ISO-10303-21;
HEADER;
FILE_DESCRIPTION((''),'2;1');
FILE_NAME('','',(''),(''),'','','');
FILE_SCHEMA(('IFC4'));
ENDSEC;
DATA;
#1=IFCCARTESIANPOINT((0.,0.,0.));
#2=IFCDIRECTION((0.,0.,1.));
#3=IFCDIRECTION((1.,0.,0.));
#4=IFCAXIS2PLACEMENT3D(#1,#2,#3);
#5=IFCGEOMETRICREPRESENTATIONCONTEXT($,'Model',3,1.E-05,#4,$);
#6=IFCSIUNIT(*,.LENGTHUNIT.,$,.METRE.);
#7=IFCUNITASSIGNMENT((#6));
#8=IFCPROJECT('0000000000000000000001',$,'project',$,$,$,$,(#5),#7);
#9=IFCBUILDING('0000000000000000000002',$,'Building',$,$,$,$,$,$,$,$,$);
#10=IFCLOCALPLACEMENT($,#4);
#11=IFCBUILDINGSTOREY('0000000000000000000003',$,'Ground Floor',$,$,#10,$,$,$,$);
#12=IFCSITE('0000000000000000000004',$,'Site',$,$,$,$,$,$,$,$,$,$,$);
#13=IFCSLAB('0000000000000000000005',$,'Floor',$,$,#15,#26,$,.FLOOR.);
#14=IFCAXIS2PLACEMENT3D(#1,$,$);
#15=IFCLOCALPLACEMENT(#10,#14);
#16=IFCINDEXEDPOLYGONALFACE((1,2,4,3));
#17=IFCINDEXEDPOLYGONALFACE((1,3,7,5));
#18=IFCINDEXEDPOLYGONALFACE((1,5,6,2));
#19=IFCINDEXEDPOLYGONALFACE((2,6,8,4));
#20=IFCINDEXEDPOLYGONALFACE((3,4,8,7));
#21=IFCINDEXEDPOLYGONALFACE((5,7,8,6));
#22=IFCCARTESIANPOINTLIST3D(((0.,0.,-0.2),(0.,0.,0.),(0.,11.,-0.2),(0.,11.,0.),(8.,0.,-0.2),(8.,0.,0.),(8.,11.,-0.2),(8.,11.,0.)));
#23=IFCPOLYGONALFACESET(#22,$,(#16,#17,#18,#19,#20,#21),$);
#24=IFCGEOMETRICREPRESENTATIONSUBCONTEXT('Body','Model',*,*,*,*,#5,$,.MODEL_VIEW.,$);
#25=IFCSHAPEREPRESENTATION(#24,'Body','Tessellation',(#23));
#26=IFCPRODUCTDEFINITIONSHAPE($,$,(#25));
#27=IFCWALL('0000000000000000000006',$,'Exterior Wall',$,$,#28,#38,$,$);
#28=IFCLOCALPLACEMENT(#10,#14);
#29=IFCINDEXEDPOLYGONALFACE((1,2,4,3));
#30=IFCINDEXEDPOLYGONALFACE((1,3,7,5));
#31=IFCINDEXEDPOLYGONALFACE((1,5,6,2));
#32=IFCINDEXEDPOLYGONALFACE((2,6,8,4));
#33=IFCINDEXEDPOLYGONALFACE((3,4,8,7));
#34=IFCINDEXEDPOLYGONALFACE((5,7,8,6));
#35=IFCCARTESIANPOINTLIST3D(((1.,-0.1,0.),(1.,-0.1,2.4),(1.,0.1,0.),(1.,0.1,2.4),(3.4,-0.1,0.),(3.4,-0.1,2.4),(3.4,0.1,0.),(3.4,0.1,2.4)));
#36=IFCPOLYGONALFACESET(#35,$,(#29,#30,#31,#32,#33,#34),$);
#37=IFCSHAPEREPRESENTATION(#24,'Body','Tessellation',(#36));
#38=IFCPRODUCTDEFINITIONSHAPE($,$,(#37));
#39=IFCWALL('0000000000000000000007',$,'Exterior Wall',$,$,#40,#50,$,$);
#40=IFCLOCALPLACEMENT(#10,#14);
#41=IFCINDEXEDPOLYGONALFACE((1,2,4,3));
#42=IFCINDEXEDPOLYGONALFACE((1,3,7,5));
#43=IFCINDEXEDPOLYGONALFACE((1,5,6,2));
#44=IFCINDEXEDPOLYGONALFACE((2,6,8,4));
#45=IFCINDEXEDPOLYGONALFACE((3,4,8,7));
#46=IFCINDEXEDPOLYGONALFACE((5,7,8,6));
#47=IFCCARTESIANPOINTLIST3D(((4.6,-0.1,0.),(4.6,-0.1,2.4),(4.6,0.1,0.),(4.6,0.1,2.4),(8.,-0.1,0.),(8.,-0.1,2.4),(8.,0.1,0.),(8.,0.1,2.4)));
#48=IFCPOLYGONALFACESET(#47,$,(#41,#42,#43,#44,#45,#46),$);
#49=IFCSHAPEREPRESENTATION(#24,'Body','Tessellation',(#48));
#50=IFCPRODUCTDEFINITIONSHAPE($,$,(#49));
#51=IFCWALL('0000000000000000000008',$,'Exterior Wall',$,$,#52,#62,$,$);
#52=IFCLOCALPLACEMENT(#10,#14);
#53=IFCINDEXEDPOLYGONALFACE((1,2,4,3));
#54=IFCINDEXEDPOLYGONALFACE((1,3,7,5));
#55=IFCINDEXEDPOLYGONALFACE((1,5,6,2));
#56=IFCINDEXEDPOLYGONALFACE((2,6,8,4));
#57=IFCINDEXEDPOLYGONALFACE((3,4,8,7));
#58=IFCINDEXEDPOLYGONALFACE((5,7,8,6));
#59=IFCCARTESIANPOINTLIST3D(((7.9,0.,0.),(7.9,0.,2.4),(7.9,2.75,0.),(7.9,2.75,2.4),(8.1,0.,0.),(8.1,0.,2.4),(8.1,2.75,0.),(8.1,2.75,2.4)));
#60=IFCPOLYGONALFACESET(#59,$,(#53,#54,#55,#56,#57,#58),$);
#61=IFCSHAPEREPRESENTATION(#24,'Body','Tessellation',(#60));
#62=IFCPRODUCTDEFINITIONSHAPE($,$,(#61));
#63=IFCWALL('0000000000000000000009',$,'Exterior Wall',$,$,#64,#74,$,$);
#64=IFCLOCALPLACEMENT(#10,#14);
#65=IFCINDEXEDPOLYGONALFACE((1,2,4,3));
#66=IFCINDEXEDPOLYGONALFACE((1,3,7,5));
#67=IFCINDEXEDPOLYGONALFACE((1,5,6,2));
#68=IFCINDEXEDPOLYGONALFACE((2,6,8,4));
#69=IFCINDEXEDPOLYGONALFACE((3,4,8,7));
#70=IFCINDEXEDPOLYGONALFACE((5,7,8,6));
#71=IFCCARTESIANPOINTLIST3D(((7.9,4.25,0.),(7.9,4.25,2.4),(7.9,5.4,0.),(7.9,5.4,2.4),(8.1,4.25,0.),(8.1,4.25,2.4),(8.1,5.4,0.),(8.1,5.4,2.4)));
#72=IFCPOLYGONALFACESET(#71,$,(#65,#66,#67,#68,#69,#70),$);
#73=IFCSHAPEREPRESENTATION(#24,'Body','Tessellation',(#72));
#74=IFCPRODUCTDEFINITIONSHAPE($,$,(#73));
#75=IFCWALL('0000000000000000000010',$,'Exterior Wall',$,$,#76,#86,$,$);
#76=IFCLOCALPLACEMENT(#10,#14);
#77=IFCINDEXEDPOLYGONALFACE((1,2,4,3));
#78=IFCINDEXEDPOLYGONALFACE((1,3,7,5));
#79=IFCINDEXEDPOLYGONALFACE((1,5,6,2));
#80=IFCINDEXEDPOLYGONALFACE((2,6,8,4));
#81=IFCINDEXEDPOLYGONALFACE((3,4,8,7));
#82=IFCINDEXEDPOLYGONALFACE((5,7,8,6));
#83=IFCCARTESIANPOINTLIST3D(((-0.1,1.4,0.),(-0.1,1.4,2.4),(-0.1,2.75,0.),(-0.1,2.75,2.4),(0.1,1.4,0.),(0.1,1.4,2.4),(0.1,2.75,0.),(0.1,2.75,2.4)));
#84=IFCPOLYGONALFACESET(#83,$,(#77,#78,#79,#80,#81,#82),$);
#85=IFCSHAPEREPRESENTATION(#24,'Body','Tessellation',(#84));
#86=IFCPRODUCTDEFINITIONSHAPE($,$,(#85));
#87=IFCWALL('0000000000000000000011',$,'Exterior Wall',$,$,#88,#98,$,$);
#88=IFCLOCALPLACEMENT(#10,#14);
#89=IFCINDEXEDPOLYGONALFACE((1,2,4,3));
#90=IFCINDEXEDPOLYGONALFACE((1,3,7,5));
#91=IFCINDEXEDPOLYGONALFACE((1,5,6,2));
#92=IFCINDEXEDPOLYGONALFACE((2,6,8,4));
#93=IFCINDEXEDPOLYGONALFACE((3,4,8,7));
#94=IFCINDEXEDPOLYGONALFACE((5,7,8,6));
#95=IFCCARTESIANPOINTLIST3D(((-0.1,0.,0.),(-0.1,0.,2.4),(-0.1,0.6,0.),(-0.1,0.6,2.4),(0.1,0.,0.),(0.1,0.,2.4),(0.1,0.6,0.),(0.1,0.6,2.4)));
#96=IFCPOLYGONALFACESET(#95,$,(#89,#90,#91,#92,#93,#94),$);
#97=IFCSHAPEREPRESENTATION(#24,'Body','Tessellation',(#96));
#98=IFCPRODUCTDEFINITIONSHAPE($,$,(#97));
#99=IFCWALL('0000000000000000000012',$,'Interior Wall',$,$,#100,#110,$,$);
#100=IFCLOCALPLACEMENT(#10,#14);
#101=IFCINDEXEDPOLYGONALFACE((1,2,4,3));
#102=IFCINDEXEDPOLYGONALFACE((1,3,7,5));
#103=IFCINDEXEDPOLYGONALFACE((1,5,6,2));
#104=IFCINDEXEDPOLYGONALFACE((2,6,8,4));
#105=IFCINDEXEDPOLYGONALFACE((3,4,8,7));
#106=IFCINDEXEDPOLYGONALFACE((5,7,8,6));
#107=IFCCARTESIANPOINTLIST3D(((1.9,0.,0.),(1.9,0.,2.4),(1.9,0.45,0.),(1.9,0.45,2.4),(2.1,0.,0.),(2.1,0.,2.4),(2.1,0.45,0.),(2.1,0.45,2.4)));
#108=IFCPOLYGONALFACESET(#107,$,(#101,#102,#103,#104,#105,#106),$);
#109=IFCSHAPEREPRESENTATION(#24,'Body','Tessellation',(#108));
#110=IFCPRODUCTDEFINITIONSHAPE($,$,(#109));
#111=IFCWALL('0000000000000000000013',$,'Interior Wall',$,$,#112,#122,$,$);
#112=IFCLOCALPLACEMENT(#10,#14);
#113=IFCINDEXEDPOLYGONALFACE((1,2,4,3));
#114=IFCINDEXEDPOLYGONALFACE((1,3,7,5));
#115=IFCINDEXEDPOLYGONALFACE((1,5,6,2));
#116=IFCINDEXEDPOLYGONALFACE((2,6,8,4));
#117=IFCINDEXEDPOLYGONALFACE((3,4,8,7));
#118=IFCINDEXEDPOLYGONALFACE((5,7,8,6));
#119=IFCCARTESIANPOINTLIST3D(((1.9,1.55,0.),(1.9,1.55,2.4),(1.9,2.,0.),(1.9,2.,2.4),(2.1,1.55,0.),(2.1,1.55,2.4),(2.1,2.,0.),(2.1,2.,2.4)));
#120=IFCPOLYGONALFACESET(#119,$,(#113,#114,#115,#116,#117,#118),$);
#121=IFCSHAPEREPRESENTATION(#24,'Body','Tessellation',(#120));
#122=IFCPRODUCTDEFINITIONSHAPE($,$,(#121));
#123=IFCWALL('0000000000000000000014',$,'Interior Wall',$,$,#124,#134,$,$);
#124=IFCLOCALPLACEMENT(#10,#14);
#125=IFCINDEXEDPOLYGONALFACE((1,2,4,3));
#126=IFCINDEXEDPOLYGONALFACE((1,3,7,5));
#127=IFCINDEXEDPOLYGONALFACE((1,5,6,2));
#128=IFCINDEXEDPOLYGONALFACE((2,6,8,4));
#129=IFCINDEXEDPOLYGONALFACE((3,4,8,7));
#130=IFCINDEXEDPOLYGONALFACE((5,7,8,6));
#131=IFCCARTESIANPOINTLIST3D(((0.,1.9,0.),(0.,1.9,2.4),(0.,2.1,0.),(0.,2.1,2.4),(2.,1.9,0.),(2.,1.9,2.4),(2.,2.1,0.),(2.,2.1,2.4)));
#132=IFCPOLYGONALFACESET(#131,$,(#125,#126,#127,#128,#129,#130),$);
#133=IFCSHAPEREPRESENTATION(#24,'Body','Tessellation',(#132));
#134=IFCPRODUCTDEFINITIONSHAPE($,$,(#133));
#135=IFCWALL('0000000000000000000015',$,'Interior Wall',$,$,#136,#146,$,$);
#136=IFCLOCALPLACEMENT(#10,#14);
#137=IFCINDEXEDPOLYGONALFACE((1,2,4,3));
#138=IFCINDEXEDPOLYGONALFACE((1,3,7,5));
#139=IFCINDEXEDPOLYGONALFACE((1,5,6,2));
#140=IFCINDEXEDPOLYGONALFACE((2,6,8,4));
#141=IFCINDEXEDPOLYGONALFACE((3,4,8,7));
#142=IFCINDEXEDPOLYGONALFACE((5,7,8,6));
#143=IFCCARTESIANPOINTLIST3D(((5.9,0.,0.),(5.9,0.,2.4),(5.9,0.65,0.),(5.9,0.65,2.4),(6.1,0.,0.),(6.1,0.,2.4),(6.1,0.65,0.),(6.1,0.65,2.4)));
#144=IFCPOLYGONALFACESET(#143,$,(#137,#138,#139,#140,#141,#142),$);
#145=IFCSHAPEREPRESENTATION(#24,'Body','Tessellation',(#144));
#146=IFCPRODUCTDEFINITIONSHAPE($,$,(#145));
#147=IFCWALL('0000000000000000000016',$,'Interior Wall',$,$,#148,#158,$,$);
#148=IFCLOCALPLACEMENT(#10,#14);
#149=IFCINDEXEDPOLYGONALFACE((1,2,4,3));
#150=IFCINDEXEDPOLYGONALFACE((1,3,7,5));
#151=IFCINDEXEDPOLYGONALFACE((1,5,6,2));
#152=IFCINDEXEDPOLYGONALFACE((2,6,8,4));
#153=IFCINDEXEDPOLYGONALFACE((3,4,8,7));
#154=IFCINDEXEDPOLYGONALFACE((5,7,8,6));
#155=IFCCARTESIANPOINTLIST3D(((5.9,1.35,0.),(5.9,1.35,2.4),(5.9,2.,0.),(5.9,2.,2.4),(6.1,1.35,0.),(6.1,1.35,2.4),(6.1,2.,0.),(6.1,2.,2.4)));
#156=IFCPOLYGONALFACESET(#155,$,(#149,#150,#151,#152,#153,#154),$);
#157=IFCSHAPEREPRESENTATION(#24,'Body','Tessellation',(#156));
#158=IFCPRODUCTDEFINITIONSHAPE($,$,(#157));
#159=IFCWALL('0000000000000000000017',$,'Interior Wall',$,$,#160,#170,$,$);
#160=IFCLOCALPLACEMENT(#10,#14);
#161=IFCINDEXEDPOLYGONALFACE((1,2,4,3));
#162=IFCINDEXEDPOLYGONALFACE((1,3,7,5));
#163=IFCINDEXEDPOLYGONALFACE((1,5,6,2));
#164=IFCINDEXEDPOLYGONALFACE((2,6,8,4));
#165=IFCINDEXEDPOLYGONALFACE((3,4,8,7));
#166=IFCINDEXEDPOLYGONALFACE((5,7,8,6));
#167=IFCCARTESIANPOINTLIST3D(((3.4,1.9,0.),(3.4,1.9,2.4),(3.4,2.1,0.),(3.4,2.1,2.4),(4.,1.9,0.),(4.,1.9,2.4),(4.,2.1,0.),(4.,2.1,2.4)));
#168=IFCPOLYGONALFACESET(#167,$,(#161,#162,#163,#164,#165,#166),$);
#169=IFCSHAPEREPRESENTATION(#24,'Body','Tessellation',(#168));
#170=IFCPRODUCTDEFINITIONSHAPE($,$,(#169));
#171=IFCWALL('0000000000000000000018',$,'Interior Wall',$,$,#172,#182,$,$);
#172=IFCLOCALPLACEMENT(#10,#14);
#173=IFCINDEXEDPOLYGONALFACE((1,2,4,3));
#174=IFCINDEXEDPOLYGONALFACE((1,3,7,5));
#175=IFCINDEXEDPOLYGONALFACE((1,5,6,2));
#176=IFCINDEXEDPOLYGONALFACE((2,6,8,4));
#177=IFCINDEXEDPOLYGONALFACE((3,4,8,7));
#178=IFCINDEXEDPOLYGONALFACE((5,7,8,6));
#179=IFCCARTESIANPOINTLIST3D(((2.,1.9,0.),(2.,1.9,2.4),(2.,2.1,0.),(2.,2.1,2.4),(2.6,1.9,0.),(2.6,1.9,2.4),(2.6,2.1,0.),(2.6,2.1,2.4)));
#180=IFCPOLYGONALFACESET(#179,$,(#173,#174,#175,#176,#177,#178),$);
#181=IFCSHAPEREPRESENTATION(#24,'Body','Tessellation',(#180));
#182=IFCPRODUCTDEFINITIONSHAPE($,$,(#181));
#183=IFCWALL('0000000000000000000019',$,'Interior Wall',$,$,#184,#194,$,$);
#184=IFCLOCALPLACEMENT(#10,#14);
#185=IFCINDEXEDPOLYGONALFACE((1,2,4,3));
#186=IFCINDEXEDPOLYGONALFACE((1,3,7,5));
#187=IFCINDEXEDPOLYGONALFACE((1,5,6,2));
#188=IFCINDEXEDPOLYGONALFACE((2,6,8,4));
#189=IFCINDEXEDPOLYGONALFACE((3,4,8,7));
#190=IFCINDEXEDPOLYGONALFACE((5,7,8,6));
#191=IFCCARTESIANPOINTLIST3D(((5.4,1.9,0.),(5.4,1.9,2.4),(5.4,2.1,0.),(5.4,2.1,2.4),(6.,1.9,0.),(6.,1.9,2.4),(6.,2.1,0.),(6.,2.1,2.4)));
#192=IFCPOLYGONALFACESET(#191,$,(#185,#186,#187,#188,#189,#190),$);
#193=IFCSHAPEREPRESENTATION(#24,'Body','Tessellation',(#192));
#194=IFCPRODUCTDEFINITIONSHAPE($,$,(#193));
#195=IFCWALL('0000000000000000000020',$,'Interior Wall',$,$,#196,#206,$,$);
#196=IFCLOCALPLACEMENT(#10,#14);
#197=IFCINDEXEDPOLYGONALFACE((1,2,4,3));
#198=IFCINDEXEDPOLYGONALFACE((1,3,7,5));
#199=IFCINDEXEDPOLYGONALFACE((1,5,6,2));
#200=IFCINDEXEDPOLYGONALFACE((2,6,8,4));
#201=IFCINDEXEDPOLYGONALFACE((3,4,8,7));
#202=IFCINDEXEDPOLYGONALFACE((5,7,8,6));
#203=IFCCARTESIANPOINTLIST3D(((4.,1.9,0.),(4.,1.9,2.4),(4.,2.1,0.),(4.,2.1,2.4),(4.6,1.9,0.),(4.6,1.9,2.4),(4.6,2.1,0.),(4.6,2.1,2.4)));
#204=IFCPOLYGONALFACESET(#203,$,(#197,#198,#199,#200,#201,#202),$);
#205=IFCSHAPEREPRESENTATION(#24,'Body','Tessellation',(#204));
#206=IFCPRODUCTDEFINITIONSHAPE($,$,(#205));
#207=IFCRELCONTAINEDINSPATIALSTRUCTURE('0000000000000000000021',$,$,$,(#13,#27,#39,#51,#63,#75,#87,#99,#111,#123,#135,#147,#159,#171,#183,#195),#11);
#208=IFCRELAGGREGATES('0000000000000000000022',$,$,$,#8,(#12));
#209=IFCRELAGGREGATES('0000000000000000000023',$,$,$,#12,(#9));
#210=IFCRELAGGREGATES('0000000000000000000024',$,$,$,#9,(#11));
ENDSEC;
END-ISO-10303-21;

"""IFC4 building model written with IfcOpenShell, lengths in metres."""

from ifc_helpers import new_model, si_unit, frame, origin_with_axes, place, context, subcontext, project, spatial, indexed_curve, outline, extrude, element, save


model = new_model("IFC4")

# Units and contexts
model_context = context("Model", 3, precision=1e-05, world=origin_with_axes())
body_context = subcontext(model_context, "Body", "Model", "MODEL_VIEW")
ifc_project = project(units=[si_unit("LENGTHUNIT", "METRE")], contexts=[model_context])

# Site, building, storey
site = spatial("IfcSite", under=ifc_project, Name="Site")
building = spatial("IfcBuilding", under=site, Name="Building")
storey_placement = place(None, origin_with_axes())
storey = spatial("IfcBuildingStorey", under=building, at=storey_placement, Name="Ground Floor")

# Slab
slab_placement = place(storey_placement, frame((0.0, 0.0, -0.2), z_axis=(0.0, 0.0, 1.0), x_axis=(1.0, 0.0, 0.0)))
element("IfcSlab", 1, at=slab_placement, inside=storey, Name="Floor", PredefinedType="FLOOR", context=body_context, shape_type="SweptSolid", body=[
    extrude(outline(indexed_curve([(0.0, 0.0), (8.0, 0.0), (8.0, 11.0), (0.0, 11.0)])), None, (0.0, 0.0, 1.0), 0.2),
])

# Walls
wall_1_placement = place(storey_placement, frame((1.0, 0.0, 0.0), z_axis=(0.0, 0.0, 1.0), x_axis=(1.0, 0.0, 0.0)))
element("IfcWall", 2, at=wall_1_placement, inside=storey, Name="Exterior Wall", context=body_context, shape_type="SweptSolid", body=[
    extrude(outline(indexed_curve([(0.0, 0.0), (0.0, 0.2), (2.4, 0.2), (2.4, 0.0), (0.0, 0.0)], self_intersect=False)), frame((0.0, -0.1, 0.0), z_axis=(0.0, 0.0, 1.0), x_axis=(1.0, 0.0, 0.0)), (0.0, 0.0, 1.0), 2.4),
])
wall_2_placement = place(storey_placement, frame((4.6, 0.0, 0.0), z_axis=(0.0, 0.0, 1.0), x_axis=(1.0, 0.0, 0.0)))
element("IfcWall", 3, at=wall_2_placement, inside=storey, Name="Exterior Wall", context=body_context, shape_type="SweptSolid", body=[
    extrude(outline(indexed_curve([(0.0, 0.0), (0.0, 0.2), (3.4, 0.2), (3.4, 0.0), (0.0, 0.0)], self_intersect=False)), frame((0.0, -0.1, 0.0), z_axis=(0.0, 0.0, 1.0), x_axis=(1.0, 0.0, 0.0)), (0.0, 0.0, 1.0), 2.4),
])
wall_3_placement = place(storey_placement, frame((8.0, 0.0, 0.0), z_axis=(0.0, 0.0, 1.0), x_axis=(0.0, 1.0, 0.0)))
element("IfcWall", 4, at=wall_3_placement, inside=storey, Name="Exterior Wall", context=body_context, shape_type="SweptSolid", body=[
    extrude(outline(indexed_curve([(0.0, 0.0), (0.0, 0.2), (2.75, 0.2), (2.75, 0.0), (0.0, 0.0)], self_intersect=False)), frame((0.0, -0.1, 0.0), z_axis=(0.0, 0.0, 1.0), x_axis=(1.0, 0.0, 0.0)), (0.0, 0.0, 1.0), 2.4),
])
wall_4_placement = place(storey_placement, frame((8.0, 4.25, 0.0), z_axis=(0.0, 0.0, 1.0), x_axis=(0.0, 1.0, 0.0)))
element("IfcWall", 5, at=wall_4_placement, inside=storey, Name="Exterior Wall", context=body_context, shape_type="SweptSolid", body=[
    extrude(outline(indexed_curve([(0.0, 0.0), (0.0, 0.2), (1.15, 0.2), (1.15, 0.0), (0.0, 0.0)], self_intersect=False)), frame((0.0, -0.1, 0.0), z_axis=(0.0, 0.0, 1.0), x_axis=(1.0, 0.0, 0.0)), (0.0, 0.0, 1.0), 2.4),
])
wall_5_placement = place(storey_placement, frame((0.0, 2.75, 0.0), z_axis=(0.0, 0.0, 1.0), x_axis=(0.0, -1.0, 0.0)))
element("IfcWall", 6, at=wall_5_placement, inside=storey, Name="Exterior Wall", context=body_context, shape_type="SweptSolid", body=[
    extrude(outline(indexed_curve([(0.0, 0.0), (0.0, 0.2), (1.35, 0.2), (1.35, 0.0), (0.0, 0.0)], self_intersect=False)), frame((0.0, -0.1, 0.0), z_axis=(0.0, 0.0, 1.0), x_axis=(1.0, 0.0, 0.0)), (0.0, 0.0, 1.0), 2.4),
])
wall_6_placement = place(storey_placement, frame((0.0, 0.6, 0.0), z_axis=(0.0, 0.0, 1.0), x_axis=(0.0, -1.0, 0.0)))
element("IfcWall", 7, at=wall_6_placement, inside=storey, Name="Exterior Wall", context=body_context, shape_type="SweptSolid", body=[
    extrude(outline(indexed_curve([(0.0, 0.0), (0.0, 0.2), (0.6, 0.2), (0.6, 0.0), (0.0, 0.0)], self_intersect=False)), frame((0.0, -0.1, 0.0), z_axis=(0.0, 0.0, 1.0), x_axis=(1.0, 0.0, 0.0)), (0.0, 0.0, 1.0), 2.4),
])
for number, where, z_axis, x_axis, name in (
    (8, (2.0, 0.0, 0.0), (0.0, 0.0, 1.0), (0.0, 1.0, 0.0), "Interior Wall"),
    (9, (2.0, 1.55, 0.0), (0.0, 0.0, 1.0), (0.0, 1.0, 0.0), "Interior Wall"),
):
    element("IfcWall", number, at=place(storey_placement, frame(where, z_axis=z_axis, x_axis=x_axis)), inside=storey, Name=name, context=body_context, shape_type="SweptSolid", body=[
        extrude(outline(indexed_curve([(0.0, 0.0), (0.0, 0.2), (0.45, 0.2), (0.45, 0.0), (0.0, 0.0)], self_intersect=False)), frame((0.0, -0.1, 0.0), z_axis=(0.0, 0.0, 1.0), x_axis=(1.0, 0.0, 0.0)), (0.0, 0.0, 1.0), 2.4),
    ])
wall_7_placement = place(storey_placement, frame((2.0, 2.0, 0.0), z_axis=(0.0, 0.0, 1.0), x_axis=(-1.0, 0.0, 0.0)))
element("IfcWall", 10, at=wall_7_placement, inside=storey, Name="Interior Wall", context=body_context, shape_type="SweptSolid", body=[
    extrude(outline(indexed_curve([(0.0, 0.0), (0.0, 0.2), (2.0, 0.2), (2.0, 0.0), (0.0, 0.0)], self_intersect=False)), frame((0.0, -0.1, 0.0), z_axis=(0.0, 0.0, 1.0), x_axis=(1.0, 0.0, 0.0)), (0.0, 0.0, 1.0), 2.4),
])
wall_8_placement = place(storey_placement, frame((6.0, 0.0, 0.0), z_axis=(0.0, 0.0, 1.0), x_axis=(0.0, 1.0, 0.0)))
element("IfcWall", 11, at=wall_8_placement, inside=storey, Name="Interior Wall", context=body_context, shape_type="SweptSolid", body=[
    extrude(outline(indexed_curve([(0.0, 0.0), (0.0, 0.2), (0.65, 0.2), (0.65, 0.0), (0.0, 0.0)], self_intersect=False)), frame((0.0, -0.1, 0.0), z_axis=(0.0, 0.0, 1.0), x_axis=(1.0, 0.0, 0.0)), (0.0, 0.0, 1.0), 2.4),
])
wall_9_placement = place(storey_placement, frame((6.0, 1.35, 0.0), z_axis=(0.0, 0.0, 1.0), x_axis=(0.0, 1.0, 0.0)))
element("IfcWall", 12, at=wall_9_placement, inside=storey, Name="Interior Wall", context=body_context, shape_type="SweptSolid", body=[
    extrude(outline(indexed_curve([(0.0, 0.0), (0.0, 0.2), (0.65, 0.2), (0.65, 0.0), (0.0, 0.0)], self_intersect=False)), frame((0.0, -0.1, 0.0), z_axis=(0.0, 0.0, 1.0), x_axis=(1.0, 0.0, 0.0)), (0.0, 0.0, 1.0), 2.4),
])
for number, where, z_axis, x_axis, name in (
    (13, (4.0, 2.0, 0.0), (0.0, 0.0, 1.0), (-1.0, 0.0, 0.0), "Interior Wall"),
    (14, (2.6, 2.0, 0.0), (0.0, 0.0, 1.0), (-1.0, 0.0, 0.0), "Interior Wall"),
):
    element("IfcWall", number, at=place(storey_placement, frame(where, z_axis=z_axis, x_axis=x_axis)), inside=storey, Name=name, context=body_context, shape_type="SweptSolid", body=[
        extrude(outline(indexed_curve([(0.0, 0.0), (0.0, 0.2), (0.6, 0.2), (0.6, 0.0), (0.0, 0.0)], self_intersect=False)), frame((0.0, -0.1, 0.0), z_axis=(0.0, 0.0, 1.0), x_axis=(1.0, 0.0, 0.0)), (0.0, 0.0, 1.0), 2.4),
    ])
for number, where, z_axis, x_axis, name in (
    (15, (6.0, 2.0, 0.0), (0.0, 0.0, 1.0), (-1.0, 0.0, 0.0), "Interior Wall"),
    (16, (4.6, 2.0, 0.0), (0.0, 0.0, 1.0), (-1.0, 0.0, 0.0), "Interior Wall"),
):
    element("IfcWall", number, at=place(storey_placement, frame(where, z_axis=z_axis, x_axis=x_axis)), inside=storey, Name=name, context=body_context, shape_type="SweptSolid", body=[
        extrude(outline(indexed_curve([(0.0, 0.0), (0.0, 0.2), (0.6, 0.2), (0.6, 0.0), (0.0, 0.0)], self_intersect=False)), frame((0.0, -0.1, 0.0), z_axis=(0.0, 0.0, 1.0), x_axis=(1.0, 0.0, 0.0)), (0.0, 0.0, 1.0), 2.4),
    ])

save(model, "model.ifc")
